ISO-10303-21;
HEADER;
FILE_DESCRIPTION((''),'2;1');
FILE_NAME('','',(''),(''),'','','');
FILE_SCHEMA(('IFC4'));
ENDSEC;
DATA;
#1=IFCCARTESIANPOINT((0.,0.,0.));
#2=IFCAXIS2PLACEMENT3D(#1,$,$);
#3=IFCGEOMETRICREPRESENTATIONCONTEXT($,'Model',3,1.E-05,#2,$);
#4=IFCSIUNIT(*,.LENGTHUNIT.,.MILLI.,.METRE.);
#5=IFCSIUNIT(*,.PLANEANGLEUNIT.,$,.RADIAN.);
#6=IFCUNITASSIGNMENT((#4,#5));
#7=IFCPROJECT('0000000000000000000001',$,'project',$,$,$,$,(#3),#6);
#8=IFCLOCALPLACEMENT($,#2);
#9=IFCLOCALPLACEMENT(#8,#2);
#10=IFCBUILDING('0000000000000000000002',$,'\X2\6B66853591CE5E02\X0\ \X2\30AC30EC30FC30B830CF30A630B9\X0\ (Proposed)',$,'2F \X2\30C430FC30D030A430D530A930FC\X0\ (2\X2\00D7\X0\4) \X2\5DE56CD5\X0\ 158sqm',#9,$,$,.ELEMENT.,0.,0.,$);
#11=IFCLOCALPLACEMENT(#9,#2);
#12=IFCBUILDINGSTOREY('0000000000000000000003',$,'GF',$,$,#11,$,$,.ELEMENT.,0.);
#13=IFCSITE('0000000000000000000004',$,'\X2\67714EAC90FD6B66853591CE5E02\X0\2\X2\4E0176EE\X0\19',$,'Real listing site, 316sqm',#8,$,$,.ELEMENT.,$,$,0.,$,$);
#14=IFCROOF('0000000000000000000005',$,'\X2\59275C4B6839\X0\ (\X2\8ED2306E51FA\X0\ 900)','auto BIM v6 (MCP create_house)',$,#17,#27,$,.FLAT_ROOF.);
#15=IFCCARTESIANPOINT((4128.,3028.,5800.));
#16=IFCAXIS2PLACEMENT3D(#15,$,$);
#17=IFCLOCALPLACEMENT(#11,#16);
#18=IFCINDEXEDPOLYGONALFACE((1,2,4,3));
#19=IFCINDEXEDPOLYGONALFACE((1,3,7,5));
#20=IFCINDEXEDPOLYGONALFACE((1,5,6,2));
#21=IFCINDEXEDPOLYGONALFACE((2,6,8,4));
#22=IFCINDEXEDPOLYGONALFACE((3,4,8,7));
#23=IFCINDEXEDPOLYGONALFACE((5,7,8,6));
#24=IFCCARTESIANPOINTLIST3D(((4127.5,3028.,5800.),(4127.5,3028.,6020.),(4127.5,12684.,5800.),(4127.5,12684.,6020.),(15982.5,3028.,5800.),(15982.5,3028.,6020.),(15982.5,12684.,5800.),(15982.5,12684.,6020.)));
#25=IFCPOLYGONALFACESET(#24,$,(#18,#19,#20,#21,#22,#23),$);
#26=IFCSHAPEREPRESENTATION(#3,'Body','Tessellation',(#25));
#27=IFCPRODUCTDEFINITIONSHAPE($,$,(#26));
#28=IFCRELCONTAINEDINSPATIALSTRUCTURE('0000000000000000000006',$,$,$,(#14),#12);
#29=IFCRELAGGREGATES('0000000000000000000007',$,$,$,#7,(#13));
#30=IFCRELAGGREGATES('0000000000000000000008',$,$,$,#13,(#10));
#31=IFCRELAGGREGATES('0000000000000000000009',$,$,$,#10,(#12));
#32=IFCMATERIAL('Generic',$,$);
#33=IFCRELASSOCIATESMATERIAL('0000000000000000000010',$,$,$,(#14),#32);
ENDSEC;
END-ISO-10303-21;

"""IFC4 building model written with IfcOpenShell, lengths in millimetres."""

from ifc_helpers import new_model, si_unit, frame, frame_2d, origin, place, context, project, spatial, rectangle, extrude, material, element, save


model = new_model("IFC4")

# Units and contexts
model_context = context("Model", 3, precision=1e-05, world=origin())
ifc_project = project(units=[si_unit("LENGTHUNIT", "METRE", prefix="MILLI"), si_unit("PLANEANGLEUNIT", "RADIAN")], contexts=[model_context])

# Site, building, storey
site_placement = place(None, origin())
site = spatial("IfcSite", under=ifc_project, at=site_placement, Name="東京都武蔵野市2丁目19", ObjectType="Real listing site, 316sqm", CompositionType="ELEMENT", RefElevation=0.0)
building_placement = place(site_placement, origin())
building = spatial("IfcBuilding", under=site, at=building_placement, Name="武蔵野市 ガレージハウス (Proposed)", ObjectType="2F ツーバイフォー (2×4) 工法 158sqm", CompositionType="ELEMENT", ElevationOfRefHeight=0.0, ElevationOfTerrain=0.0)
storey_placement = place(building_placement, origin())
storey = spatial("IfcBuildingStorey", under=building, at=storey_placement, Name="GF", CompositionType="ELEMENT", Elevation=0.0)

# Shared definitions
ifc_material = material(Name="Generic")

# Roof
roof_placement = place(storey_placement, frame((4128.0, 3028.0, 5800.0)))
element("IfcRoof", 1, at=roof_placement, inside=storey, material=ifc_material, Name="大屋根 (軒の出 900)", Description="auto BIM v6 (MCP create_house)", PredefinedType="FLAT_ROOF", context=model_context, shape_type="SweptSolid", body=[
    extrude(rectangle(XDim=11855.0, YDim=9656.0, at=frame_2d((5927.0, 4828.0))), frame((4128.0, 3028.0, 5800.0)), (0.0, 0.0, 1.0), 220.0),
])

save(model, "model.ifc")
